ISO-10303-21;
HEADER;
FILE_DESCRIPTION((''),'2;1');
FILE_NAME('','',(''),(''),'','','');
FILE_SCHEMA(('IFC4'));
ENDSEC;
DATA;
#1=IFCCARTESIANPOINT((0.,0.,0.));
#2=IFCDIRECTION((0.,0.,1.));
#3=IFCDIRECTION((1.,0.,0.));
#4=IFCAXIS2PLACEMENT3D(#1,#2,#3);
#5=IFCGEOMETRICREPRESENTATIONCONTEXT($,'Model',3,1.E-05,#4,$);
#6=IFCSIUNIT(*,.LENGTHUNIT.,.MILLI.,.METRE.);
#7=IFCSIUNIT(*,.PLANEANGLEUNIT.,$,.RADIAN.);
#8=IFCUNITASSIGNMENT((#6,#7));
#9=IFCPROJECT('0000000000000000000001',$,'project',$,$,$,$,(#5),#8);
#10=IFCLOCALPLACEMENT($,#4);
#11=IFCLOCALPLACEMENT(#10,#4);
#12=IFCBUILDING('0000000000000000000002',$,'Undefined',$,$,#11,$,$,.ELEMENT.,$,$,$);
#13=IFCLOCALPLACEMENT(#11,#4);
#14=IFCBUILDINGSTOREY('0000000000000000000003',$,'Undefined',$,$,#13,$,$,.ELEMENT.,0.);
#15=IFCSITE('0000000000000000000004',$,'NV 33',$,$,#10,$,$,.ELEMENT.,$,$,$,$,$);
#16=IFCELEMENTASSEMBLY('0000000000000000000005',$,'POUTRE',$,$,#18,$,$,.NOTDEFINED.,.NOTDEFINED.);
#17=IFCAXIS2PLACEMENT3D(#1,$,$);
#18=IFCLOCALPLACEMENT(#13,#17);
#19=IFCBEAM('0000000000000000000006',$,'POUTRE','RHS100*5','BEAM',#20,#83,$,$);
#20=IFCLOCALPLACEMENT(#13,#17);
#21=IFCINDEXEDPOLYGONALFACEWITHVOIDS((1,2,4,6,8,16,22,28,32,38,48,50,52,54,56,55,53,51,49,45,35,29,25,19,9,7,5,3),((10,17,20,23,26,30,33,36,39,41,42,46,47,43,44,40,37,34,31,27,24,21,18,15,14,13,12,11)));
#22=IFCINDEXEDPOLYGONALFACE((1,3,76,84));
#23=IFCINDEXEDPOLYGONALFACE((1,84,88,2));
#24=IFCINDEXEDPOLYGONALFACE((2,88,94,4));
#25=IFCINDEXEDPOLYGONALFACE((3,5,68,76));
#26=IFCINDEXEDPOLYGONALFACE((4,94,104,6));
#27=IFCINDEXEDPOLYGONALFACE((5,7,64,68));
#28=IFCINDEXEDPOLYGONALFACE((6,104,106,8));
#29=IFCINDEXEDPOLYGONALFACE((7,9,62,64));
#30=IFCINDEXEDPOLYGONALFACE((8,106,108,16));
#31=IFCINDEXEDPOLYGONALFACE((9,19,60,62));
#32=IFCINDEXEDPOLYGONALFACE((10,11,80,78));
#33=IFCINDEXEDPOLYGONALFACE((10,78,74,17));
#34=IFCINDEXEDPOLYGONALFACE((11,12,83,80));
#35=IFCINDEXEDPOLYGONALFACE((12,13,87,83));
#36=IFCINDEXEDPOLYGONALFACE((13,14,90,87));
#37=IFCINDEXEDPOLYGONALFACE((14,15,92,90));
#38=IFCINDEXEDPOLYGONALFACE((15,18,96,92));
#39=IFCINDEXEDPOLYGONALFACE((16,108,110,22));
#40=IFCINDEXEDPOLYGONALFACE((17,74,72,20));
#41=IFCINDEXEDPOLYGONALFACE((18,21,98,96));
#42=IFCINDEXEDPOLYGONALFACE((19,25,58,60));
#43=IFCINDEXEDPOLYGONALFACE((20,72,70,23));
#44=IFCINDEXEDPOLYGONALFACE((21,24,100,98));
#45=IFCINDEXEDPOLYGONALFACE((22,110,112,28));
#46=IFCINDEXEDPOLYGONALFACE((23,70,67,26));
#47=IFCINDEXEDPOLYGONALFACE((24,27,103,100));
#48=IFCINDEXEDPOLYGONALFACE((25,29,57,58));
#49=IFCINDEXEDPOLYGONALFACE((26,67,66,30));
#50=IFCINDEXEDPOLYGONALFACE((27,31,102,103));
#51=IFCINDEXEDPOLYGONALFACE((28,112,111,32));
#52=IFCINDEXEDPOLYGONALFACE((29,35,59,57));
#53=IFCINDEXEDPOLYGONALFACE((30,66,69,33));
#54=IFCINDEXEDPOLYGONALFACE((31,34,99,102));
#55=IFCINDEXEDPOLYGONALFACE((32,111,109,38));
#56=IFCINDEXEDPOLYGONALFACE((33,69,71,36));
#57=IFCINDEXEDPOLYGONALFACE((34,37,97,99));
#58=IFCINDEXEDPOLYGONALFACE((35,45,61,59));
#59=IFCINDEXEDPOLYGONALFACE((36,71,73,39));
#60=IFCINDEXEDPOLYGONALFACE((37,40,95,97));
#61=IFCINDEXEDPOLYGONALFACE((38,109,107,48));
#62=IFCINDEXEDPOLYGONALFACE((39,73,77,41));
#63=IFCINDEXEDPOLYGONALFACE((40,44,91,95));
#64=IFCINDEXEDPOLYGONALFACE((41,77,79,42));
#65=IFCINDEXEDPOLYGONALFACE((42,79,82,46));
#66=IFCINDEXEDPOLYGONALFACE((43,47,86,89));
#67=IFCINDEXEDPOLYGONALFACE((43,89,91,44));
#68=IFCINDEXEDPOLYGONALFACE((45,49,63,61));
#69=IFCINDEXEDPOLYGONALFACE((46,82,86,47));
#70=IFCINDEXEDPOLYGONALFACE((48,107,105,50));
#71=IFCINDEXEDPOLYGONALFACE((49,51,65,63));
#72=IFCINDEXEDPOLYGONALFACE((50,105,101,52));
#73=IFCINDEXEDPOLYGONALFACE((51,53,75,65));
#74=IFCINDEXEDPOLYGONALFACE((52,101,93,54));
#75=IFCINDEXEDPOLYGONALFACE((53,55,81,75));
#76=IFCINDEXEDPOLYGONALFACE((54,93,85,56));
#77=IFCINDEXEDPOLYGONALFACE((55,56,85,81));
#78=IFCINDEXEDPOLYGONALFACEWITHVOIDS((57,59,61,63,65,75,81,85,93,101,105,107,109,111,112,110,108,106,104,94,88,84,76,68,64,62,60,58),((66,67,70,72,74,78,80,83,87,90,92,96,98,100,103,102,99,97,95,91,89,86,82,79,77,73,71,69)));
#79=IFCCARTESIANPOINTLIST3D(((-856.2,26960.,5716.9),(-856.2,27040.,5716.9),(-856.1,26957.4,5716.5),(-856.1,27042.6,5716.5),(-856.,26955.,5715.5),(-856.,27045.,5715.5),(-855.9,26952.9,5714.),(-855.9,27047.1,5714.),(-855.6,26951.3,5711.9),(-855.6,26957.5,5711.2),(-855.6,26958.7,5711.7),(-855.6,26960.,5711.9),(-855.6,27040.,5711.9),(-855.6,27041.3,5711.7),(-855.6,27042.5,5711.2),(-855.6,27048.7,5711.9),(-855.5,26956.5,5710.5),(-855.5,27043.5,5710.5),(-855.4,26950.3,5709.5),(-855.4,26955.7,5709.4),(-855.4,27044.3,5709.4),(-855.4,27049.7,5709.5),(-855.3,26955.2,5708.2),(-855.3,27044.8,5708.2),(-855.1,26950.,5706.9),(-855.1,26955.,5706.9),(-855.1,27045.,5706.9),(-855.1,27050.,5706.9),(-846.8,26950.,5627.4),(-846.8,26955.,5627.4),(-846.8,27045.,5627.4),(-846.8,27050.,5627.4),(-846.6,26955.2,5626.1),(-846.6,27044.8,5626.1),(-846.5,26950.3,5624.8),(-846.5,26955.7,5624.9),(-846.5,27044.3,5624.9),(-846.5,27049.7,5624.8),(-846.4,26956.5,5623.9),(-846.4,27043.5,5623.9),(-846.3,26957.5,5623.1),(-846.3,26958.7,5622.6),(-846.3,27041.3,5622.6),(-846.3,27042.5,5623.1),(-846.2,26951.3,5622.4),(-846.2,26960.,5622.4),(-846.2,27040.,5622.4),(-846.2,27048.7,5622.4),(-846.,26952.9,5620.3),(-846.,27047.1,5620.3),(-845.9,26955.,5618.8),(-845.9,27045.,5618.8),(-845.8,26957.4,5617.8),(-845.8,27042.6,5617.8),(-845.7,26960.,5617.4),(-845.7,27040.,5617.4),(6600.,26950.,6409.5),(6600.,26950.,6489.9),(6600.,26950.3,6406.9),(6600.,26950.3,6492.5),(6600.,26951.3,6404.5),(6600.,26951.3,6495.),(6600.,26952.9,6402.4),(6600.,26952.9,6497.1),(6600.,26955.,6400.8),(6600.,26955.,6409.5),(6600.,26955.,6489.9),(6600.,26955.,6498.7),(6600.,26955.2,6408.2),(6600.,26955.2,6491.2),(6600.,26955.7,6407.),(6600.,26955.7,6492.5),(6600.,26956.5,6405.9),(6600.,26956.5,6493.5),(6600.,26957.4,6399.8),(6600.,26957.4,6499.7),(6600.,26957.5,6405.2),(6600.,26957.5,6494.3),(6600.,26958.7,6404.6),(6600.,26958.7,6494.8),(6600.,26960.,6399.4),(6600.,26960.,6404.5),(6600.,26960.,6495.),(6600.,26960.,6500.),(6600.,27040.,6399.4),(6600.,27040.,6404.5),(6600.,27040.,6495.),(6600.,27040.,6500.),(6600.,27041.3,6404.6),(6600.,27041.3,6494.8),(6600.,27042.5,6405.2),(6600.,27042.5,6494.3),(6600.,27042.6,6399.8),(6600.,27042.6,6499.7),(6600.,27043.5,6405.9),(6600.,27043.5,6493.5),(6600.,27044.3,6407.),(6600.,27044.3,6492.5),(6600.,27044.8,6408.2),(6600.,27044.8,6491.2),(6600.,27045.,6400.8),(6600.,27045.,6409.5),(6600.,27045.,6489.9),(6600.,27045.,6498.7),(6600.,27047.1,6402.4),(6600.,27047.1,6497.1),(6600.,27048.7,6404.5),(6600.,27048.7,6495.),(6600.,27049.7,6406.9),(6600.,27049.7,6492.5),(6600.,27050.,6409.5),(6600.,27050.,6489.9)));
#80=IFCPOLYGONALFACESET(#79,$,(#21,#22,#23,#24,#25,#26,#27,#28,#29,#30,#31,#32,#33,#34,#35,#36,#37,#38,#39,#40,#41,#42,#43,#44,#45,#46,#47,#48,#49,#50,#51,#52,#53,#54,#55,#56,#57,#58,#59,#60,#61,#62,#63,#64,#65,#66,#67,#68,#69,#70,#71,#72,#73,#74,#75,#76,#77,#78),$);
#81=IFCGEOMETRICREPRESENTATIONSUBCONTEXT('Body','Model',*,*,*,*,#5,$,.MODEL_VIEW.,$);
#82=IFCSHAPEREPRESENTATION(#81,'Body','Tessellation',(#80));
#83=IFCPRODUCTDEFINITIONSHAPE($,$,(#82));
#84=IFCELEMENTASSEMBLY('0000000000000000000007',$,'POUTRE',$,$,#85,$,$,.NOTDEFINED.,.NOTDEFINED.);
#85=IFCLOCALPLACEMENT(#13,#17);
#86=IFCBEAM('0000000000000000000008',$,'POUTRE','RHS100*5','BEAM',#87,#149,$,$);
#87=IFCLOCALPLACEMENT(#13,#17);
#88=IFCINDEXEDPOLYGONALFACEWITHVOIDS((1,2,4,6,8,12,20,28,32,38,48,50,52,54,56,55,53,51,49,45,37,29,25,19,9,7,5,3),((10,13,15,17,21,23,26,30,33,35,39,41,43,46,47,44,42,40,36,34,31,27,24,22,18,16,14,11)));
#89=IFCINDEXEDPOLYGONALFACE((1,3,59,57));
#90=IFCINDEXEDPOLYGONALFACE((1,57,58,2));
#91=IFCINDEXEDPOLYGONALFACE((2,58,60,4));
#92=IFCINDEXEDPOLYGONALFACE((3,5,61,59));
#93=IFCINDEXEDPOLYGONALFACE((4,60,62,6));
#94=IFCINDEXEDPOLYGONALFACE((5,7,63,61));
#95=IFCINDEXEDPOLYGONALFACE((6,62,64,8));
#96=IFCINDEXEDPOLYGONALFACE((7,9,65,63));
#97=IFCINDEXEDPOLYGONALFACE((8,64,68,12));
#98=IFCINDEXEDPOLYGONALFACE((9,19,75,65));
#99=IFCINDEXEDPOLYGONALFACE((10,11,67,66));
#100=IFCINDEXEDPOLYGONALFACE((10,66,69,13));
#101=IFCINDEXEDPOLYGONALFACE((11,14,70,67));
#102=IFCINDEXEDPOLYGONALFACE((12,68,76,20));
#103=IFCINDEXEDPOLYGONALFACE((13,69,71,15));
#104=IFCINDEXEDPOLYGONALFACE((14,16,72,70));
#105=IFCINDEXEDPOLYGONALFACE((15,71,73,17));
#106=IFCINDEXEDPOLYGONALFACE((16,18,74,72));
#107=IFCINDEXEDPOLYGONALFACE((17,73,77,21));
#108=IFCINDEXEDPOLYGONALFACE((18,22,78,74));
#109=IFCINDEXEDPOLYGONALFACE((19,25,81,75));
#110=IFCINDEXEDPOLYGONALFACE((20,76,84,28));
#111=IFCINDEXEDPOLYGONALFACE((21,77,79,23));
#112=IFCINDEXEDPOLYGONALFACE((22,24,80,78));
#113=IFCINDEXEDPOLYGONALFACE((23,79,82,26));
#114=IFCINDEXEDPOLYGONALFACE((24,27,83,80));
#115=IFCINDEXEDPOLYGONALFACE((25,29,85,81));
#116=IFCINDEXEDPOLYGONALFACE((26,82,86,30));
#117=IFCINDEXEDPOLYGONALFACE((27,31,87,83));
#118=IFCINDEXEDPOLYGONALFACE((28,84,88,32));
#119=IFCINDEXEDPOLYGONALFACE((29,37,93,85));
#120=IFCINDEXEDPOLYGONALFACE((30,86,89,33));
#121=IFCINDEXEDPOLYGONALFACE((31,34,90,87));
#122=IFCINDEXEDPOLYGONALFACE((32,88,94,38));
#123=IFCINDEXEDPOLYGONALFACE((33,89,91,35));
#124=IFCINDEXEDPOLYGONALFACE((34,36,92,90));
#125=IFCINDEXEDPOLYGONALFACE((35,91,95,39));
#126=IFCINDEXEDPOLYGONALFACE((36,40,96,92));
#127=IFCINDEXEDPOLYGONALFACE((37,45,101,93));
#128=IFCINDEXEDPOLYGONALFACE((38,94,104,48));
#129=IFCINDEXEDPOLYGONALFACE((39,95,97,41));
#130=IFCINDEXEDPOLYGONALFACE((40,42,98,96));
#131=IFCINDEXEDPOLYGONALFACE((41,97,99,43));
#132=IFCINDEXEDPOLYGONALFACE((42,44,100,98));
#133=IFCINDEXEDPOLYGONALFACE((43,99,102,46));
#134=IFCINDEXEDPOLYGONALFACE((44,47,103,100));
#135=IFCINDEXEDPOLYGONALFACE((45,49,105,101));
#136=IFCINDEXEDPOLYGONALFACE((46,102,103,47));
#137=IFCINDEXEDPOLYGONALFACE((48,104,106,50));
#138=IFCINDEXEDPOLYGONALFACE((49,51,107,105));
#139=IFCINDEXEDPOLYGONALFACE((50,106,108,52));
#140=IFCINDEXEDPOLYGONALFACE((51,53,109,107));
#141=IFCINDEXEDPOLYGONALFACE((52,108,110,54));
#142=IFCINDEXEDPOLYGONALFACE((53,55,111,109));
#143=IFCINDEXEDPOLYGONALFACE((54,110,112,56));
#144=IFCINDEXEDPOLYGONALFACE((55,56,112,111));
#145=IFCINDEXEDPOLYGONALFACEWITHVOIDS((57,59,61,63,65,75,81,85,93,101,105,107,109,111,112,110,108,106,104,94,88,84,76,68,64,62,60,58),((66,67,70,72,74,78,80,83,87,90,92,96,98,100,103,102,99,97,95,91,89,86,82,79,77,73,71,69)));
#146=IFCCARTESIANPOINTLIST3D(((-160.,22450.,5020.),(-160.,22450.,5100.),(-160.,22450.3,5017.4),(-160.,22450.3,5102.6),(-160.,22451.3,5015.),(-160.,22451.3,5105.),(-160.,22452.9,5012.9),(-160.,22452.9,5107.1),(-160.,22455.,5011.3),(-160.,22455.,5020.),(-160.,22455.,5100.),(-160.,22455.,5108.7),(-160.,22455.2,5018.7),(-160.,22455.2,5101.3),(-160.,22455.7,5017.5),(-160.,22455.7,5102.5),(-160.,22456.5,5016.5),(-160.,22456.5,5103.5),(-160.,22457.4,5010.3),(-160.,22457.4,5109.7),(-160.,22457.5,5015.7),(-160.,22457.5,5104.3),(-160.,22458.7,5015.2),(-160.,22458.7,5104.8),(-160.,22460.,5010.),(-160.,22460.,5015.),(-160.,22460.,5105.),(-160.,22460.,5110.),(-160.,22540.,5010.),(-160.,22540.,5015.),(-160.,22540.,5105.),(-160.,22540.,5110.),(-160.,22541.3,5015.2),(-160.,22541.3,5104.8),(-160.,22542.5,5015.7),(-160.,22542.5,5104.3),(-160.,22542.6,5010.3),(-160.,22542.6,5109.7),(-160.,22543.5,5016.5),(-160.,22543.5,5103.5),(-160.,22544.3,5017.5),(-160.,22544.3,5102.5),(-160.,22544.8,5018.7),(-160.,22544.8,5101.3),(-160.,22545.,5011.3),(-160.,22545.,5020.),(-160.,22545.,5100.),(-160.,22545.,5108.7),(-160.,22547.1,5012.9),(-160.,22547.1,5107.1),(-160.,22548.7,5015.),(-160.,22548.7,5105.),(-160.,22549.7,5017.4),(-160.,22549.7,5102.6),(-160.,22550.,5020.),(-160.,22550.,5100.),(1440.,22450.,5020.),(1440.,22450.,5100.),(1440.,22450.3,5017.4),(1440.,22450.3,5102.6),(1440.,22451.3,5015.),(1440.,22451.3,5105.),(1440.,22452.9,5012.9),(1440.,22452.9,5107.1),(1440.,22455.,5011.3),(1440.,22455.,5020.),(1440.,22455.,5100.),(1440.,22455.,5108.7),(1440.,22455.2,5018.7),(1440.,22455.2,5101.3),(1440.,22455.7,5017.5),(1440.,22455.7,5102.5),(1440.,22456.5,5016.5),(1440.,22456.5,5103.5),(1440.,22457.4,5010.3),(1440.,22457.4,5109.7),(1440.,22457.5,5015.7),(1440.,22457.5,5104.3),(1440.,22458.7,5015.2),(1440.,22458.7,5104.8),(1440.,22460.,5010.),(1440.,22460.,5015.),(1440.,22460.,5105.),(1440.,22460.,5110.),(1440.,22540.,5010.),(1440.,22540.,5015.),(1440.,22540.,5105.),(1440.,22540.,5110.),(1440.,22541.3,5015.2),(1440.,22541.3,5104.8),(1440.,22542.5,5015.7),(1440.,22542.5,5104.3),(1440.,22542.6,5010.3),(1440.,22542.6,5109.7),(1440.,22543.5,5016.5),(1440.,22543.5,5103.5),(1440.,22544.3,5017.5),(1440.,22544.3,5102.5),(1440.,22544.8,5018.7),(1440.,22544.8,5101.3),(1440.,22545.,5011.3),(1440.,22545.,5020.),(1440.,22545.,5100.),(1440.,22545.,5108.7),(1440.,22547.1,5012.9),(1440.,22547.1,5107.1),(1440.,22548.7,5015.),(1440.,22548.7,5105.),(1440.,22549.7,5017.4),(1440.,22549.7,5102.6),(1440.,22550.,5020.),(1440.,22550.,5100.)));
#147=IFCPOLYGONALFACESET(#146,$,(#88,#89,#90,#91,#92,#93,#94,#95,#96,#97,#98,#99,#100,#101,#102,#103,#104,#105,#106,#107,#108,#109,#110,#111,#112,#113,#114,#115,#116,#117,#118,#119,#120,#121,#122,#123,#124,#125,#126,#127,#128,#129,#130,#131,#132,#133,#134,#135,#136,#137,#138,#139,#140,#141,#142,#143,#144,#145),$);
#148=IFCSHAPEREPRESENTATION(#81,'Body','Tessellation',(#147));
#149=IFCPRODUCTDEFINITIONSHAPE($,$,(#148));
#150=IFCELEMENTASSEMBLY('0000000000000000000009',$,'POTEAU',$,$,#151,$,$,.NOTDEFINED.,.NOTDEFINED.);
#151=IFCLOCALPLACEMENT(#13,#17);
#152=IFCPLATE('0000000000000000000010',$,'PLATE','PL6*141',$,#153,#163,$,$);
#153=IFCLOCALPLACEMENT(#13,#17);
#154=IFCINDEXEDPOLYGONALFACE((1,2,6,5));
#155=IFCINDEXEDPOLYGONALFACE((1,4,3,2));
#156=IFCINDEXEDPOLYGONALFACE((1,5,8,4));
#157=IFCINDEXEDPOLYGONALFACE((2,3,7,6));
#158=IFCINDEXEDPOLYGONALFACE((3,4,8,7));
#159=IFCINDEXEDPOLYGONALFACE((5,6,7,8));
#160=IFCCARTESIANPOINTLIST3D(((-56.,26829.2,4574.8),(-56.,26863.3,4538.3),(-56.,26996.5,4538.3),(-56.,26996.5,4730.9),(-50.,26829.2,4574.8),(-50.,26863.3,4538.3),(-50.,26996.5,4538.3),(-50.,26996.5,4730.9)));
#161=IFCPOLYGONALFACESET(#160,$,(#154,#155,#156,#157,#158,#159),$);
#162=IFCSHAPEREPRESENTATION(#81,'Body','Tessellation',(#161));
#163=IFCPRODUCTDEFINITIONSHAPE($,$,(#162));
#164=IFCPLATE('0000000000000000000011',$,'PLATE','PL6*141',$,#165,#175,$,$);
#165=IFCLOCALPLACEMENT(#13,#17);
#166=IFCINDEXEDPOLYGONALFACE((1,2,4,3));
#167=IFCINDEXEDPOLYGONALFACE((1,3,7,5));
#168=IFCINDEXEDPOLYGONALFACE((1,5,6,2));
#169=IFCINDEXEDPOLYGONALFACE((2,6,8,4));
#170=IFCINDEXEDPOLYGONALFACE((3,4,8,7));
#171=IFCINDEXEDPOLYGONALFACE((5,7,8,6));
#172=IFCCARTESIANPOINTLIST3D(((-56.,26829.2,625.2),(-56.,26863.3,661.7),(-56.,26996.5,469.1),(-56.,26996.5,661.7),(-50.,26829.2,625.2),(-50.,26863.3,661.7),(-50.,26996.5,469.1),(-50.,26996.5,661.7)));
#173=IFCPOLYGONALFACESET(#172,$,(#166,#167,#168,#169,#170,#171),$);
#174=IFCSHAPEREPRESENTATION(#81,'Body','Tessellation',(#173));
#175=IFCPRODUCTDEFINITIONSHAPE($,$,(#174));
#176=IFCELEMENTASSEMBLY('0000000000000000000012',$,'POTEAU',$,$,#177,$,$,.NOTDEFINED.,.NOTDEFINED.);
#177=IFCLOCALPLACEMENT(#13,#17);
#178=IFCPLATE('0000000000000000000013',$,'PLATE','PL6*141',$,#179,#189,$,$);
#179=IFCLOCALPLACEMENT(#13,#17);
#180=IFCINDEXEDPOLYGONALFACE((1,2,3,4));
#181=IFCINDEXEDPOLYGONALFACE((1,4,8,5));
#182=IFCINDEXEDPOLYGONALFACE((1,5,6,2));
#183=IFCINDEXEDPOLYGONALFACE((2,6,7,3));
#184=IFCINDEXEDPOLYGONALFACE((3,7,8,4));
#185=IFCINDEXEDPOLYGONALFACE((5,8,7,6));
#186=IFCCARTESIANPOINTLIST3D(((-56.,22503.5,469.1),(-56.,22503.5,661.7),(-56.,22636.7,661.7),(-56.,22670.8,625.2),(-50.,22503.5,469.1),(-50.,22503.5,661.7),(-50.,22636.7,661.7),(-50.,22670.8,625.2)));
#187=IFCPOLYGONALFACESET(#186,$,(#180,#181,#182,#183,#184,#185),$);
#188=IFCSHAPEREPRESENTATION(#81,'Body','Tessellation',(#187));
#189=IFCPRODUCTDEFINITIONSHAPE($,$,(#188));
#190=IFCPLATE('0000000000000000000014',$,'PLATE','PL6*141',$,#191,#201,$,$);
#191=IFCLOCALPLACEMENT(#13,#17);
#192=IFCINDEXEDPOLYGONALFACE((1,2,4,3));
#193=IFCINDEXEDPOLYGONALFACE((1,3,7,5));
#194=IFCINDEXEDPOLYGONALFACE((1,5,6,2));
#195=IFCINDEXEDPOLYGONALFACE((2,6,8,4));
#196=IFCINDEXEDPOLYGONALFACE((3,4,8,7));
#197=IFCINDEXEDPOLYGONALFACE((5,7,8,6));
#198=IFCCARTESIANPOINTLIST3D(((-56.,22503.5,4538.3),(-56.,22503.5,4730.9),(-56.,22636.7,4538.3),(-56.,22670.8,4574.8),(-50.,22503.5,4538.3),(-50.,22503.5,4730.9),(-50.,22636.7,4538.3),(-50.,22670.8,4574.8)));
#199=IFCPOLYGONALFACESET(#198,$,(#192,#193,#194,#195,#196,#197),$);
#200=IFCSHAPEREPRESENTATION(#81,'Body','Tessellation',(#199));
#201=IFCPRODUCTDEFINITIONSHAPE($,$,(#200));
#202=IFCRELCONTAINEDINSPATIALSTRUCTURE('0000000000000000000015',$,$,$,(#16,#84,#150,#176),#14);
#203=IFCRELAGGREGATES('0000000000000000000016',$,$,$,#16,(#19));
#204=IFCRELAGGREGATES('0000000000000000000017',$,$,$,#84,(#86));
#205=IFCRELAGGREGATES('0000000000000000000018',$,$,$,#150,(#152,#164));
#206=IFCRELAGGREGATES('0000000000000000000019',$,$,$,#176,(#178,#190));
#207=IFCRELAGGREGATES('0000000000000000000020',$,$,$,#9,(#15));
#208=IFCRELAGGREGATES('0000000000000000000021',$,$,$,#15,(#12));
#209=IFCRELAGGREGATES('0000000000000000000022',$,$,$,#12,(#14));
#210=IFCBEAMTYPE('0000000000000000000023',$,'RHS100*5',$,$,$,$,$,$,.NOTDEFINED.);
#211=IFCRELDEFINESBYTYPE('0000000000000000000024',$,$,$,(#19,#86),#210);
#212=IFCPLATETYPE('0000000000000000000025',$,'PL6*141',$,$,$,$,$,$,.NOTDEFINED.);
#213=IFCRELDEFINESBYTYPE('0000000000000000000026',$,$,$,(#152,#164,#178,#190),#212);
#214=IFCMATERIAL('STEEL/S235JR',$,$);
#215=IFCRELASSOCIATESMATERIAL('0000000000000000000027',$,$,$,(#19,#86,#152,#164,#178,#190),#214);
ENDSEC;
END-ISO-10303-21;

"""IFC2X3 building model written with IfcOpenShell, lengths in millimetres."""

from ifc_helpers import new_model, si_unit, frame, origin_with_axes, origin_2d_with_axis, place, context, subcontext, project, spatial, polyline, hollow_rectangle, outline, extrude, clip, halfspace, material, type_object, element, aggregate, save


model = new_model("IFC2X3")

# Units and contexts
model_context = context("Model", 3, precision=1e-05, world=origin_with_axes())
body_context = subcontext(model_context, "Body", "Model", "MODEL_VIEW")
ifc_project = project(units=[si_unit("LENGTHUNIT", "METRE", prefix="MILLI"), si_unit("PLANEANGLEUNIT", "RADIAN")], contexts=[model_context])

# Site, building, storey
site_placement = place(None, origin_with_axes())
site = spatial("IfcSite", under=ifc_project, at=site_placement, Name="NV 33", CompositionType="ELEMENT")
building_placement = place(site_placement, origin_with_axes())
building = spatial("IfcBuilding", under=site, at=building_placement, Name="Undefined", CompositionType="ELEMENT")
storey_placement = place(building_placement, origin_with_axes())
storey = spatial("IfcBuildingStorey", under=building, at=storey_placement, Name="Undefined", CompositionType="ELEMENT", Elevation=0.0)

# Shared definitions
ifc_material_1 = material(Name="STEEL/S235JR")
beam_type_1 = type_object("IfcBeamType", Name="RHS100*5", PredefinedType="NOTDEFINED")

# Element assembly, beam
assembly_1_placement = place(storey_placement, origin_with_axes())
assembly_1 = element("IfcElementAssembly", 1, at=assembly_1_placement, inside=storey, Name="POUTRE", AssemblyPlace="NOTDEFINED", PredefinedType="NOTDEFINED")
beam_1_placement = place(assembly_1_placement, frame((-850.9, 27000.0, 5667.2), z_axis=(0.104455, 0.0, -0.99453), x_axis=(0.99453, 0.0, 0.104455)))
beam_1 = element("IfcBeam", 2, at=beam_1_placement, type_object=beam_type_1, material=ifc_material_1, Name="POUTRE", Description="RHS100*5", ObjectType="BEAM", context=body_context, shape_type="Clipping", body=[
    clip(extrude(hollow_rectangle(XDim=100.0, YDim=100.0, WallThickness=5.0, InnerFilletRadius=5.0, OuterFilletRadius=10.0, at=origin_2d_with_axis()), frame((7527.2, 0.0, 0.0), z_axis=(-1.0, 0.0, 0.0), x_axis=(0.0, -1.0, 0.0)), (0.0, 0.0, 1.0), 7527.2), halfspace(frame((7497.2, -50.0, -50.0), z_axis=(0.99453, 0.0, 0.104455), x_axis=(-0.104455, 0.0, 0.99453)), False)),
])
aggregate(assembly_1, [beam_1])

# Element assembly, beam
assembly_2_placement = place(storey_placement, origin_with_axes())
assembly_2 = element("IfcElementAssembly", 3, at=assembly_2_placement, inside=storey, Name="POUTRE", AssemblyPlace="NOTDEFINED", PredefinedType="NOTDEFINED")
beam_2_placement = place(assembly_2_placement, frame((-160.0, 22500.0, 5060.0), z_axis=(0.0, -1.0, 0.0), x_axis=(1.0, 0.0, 0.0)))
beam_2 = element("IfcBeam", 4, at=beam_2_placement, type_object=beam_type_1, material=ifc_material_1, Name="POUTRE", Description="RHS100*5", ObjectType="BEAM", context=body_context, shape_type="SweptSolid", body=[
    extrude(hollow_rectangle(XDim=100.0, YDim=100.0, WallThickness=5.0, InnerFilletRadius=5.0, OuterFilletRadius=10.0, at=origin_2d_with_axis()), frame((1600.0, 0.0, 0.0), z_axis=(-1.0, 0.0, 0.0), x_axis=(0.0, -1.0, 0.0)), (0.0, 0.0, 1.0), 1600.0),
])
aggregate(assembly_2, [beam_2])

# Element assemblies, plates
assembly_3_placement = place(storey_placement, origin_with_axes())
assembly_3 = element("IfcElementAssembly", 5, at=assembly_3_placement, inside=storey, Name="POTEAU", AssemblyPlace="NOTDEFINED", PredefinedType="NOTDEFINED")
plate_type_1 = type_object("IfcPlateType", Name="PL6*141", PredefinedType="NOTDEFINED")
plate_1_placement = place(assembly_3_placement, frame((-53.0, 26996.5, 4538.3), z_axis=(1.0, 0.0, 0.0), x_axis=(0.0, 0.0, 1.0)))
plate_1 = element("IfcPlate", 6, at=plate_1_placement, type_object=plate_type_1, material=ifc_material_1, Name="PLATE", Description="PL6*141", context=body_context, shape_type="SweptSolid", body=[
    extrude(outline(polyline([(0.0, 0.0), (192.6, 0.0), (36.6, 167.2), (0.0, 133.1), (0.0, 0.0)])), frame((0.0, 0.0, -3.0), z_axis=(0.0, 0.0, 1.0), x_axis=(1.0, 0.0, 0.0)), (0.0, 0.0, 1.0), 6.0),
])
plate_2_placement = place(assembly_3_placement, frame((-53.0, 26996.5, 469.1), z_axis=(1.0, 0.0, 0.0), x_axis=(0.0, 0.0, 1.0)))
plate_2 = element("IfcPlate", 7, at=plate_2_placement, type_object=plate_type_1, material=ifc_material_1, Name="PLATE", Description="PL6*141", context=body_context, shape_type="SweptSolid", body=[
    extrude(outline(polyline([(0.0, 0.0), (192.6, 0.0), (192.6, 133.1), (156.1, 167.2), (0.0, 0.0)])), frame((0.0, 0.0, -3.0), z_axis=(0.0, 0.0, 1.0), x_axis=(1.0, 0.0, 0.0)), (0.0, 0.0, 1.0), 6.0),
])
assembly_4_placement = place(storey_placement, origin_with_axes())
assembly_4 = element("IfcElementAssembly", 8, at=assembly_4_placement, inside=storey, Name="POTEAU", AssemblyPlace="NOTDEFINED", PredefinedType="NOTDEFINED")
plate_3_placement = place(assembly_4_placement, frame((-53.0, 22503.5, 661.7), z_axis=(1.0, 0.0, 0.0), x_axis=(0.0, 0.0, -1.0)))
plate_3 = element("IfcPlate", 9, at=plate_3_placement, type_object=plate_type_1, material=ifc_material_1, Name="PLATE", Description="PL6*141", context=body_context, shape_type="SweptSolid", body=[
    extrude(outline(polyline([(0.0, 0.0), (192.6, 0.0), (36.6, 167.2), (0.0, 133.1), (0.0, 0.0)])), frame((0.0, 0.0, -3.0), z_axis=(0.0, 0.0, 1.0), x_axis=(1.0, 0.0, 0.0)), (0.0, 0.0, 1.0), 6.0),
])
plate_4_placement = place(assembly_4_placement, frame((-53.0, 22503.5, 4730.9), z_axis=(1.0, 0.0, 0.0), x_axis=(0.0, 0.0, -1.0)))
plate_4 = element("IfcPlate", 10, at=plate_4_placement, type_object=plate_type_1, material=ifc_material_1, Name="PLATE", Description="PL6*141", context=body_context, shape_type="SweptSolid", body=[
    extrude(outline(polyline([(0.0, 0.0), (192.6, 0.0), (192.6, 133.1), (156.1, 167.2), (0.0, 0.0)])), frame((0.0, 0.0, -3.0), z_axis=(0.0, 0.0, 1.0), x_axis=(1.0, 0.0, 0.0)), (0.0, 0.0, 1.0), 6.0),
])

aggregate(assembly_3, [plate_1, plate_2])
aggregate(assembly_4, [plate_3, plate_4])

save(model, "model.ifc")
